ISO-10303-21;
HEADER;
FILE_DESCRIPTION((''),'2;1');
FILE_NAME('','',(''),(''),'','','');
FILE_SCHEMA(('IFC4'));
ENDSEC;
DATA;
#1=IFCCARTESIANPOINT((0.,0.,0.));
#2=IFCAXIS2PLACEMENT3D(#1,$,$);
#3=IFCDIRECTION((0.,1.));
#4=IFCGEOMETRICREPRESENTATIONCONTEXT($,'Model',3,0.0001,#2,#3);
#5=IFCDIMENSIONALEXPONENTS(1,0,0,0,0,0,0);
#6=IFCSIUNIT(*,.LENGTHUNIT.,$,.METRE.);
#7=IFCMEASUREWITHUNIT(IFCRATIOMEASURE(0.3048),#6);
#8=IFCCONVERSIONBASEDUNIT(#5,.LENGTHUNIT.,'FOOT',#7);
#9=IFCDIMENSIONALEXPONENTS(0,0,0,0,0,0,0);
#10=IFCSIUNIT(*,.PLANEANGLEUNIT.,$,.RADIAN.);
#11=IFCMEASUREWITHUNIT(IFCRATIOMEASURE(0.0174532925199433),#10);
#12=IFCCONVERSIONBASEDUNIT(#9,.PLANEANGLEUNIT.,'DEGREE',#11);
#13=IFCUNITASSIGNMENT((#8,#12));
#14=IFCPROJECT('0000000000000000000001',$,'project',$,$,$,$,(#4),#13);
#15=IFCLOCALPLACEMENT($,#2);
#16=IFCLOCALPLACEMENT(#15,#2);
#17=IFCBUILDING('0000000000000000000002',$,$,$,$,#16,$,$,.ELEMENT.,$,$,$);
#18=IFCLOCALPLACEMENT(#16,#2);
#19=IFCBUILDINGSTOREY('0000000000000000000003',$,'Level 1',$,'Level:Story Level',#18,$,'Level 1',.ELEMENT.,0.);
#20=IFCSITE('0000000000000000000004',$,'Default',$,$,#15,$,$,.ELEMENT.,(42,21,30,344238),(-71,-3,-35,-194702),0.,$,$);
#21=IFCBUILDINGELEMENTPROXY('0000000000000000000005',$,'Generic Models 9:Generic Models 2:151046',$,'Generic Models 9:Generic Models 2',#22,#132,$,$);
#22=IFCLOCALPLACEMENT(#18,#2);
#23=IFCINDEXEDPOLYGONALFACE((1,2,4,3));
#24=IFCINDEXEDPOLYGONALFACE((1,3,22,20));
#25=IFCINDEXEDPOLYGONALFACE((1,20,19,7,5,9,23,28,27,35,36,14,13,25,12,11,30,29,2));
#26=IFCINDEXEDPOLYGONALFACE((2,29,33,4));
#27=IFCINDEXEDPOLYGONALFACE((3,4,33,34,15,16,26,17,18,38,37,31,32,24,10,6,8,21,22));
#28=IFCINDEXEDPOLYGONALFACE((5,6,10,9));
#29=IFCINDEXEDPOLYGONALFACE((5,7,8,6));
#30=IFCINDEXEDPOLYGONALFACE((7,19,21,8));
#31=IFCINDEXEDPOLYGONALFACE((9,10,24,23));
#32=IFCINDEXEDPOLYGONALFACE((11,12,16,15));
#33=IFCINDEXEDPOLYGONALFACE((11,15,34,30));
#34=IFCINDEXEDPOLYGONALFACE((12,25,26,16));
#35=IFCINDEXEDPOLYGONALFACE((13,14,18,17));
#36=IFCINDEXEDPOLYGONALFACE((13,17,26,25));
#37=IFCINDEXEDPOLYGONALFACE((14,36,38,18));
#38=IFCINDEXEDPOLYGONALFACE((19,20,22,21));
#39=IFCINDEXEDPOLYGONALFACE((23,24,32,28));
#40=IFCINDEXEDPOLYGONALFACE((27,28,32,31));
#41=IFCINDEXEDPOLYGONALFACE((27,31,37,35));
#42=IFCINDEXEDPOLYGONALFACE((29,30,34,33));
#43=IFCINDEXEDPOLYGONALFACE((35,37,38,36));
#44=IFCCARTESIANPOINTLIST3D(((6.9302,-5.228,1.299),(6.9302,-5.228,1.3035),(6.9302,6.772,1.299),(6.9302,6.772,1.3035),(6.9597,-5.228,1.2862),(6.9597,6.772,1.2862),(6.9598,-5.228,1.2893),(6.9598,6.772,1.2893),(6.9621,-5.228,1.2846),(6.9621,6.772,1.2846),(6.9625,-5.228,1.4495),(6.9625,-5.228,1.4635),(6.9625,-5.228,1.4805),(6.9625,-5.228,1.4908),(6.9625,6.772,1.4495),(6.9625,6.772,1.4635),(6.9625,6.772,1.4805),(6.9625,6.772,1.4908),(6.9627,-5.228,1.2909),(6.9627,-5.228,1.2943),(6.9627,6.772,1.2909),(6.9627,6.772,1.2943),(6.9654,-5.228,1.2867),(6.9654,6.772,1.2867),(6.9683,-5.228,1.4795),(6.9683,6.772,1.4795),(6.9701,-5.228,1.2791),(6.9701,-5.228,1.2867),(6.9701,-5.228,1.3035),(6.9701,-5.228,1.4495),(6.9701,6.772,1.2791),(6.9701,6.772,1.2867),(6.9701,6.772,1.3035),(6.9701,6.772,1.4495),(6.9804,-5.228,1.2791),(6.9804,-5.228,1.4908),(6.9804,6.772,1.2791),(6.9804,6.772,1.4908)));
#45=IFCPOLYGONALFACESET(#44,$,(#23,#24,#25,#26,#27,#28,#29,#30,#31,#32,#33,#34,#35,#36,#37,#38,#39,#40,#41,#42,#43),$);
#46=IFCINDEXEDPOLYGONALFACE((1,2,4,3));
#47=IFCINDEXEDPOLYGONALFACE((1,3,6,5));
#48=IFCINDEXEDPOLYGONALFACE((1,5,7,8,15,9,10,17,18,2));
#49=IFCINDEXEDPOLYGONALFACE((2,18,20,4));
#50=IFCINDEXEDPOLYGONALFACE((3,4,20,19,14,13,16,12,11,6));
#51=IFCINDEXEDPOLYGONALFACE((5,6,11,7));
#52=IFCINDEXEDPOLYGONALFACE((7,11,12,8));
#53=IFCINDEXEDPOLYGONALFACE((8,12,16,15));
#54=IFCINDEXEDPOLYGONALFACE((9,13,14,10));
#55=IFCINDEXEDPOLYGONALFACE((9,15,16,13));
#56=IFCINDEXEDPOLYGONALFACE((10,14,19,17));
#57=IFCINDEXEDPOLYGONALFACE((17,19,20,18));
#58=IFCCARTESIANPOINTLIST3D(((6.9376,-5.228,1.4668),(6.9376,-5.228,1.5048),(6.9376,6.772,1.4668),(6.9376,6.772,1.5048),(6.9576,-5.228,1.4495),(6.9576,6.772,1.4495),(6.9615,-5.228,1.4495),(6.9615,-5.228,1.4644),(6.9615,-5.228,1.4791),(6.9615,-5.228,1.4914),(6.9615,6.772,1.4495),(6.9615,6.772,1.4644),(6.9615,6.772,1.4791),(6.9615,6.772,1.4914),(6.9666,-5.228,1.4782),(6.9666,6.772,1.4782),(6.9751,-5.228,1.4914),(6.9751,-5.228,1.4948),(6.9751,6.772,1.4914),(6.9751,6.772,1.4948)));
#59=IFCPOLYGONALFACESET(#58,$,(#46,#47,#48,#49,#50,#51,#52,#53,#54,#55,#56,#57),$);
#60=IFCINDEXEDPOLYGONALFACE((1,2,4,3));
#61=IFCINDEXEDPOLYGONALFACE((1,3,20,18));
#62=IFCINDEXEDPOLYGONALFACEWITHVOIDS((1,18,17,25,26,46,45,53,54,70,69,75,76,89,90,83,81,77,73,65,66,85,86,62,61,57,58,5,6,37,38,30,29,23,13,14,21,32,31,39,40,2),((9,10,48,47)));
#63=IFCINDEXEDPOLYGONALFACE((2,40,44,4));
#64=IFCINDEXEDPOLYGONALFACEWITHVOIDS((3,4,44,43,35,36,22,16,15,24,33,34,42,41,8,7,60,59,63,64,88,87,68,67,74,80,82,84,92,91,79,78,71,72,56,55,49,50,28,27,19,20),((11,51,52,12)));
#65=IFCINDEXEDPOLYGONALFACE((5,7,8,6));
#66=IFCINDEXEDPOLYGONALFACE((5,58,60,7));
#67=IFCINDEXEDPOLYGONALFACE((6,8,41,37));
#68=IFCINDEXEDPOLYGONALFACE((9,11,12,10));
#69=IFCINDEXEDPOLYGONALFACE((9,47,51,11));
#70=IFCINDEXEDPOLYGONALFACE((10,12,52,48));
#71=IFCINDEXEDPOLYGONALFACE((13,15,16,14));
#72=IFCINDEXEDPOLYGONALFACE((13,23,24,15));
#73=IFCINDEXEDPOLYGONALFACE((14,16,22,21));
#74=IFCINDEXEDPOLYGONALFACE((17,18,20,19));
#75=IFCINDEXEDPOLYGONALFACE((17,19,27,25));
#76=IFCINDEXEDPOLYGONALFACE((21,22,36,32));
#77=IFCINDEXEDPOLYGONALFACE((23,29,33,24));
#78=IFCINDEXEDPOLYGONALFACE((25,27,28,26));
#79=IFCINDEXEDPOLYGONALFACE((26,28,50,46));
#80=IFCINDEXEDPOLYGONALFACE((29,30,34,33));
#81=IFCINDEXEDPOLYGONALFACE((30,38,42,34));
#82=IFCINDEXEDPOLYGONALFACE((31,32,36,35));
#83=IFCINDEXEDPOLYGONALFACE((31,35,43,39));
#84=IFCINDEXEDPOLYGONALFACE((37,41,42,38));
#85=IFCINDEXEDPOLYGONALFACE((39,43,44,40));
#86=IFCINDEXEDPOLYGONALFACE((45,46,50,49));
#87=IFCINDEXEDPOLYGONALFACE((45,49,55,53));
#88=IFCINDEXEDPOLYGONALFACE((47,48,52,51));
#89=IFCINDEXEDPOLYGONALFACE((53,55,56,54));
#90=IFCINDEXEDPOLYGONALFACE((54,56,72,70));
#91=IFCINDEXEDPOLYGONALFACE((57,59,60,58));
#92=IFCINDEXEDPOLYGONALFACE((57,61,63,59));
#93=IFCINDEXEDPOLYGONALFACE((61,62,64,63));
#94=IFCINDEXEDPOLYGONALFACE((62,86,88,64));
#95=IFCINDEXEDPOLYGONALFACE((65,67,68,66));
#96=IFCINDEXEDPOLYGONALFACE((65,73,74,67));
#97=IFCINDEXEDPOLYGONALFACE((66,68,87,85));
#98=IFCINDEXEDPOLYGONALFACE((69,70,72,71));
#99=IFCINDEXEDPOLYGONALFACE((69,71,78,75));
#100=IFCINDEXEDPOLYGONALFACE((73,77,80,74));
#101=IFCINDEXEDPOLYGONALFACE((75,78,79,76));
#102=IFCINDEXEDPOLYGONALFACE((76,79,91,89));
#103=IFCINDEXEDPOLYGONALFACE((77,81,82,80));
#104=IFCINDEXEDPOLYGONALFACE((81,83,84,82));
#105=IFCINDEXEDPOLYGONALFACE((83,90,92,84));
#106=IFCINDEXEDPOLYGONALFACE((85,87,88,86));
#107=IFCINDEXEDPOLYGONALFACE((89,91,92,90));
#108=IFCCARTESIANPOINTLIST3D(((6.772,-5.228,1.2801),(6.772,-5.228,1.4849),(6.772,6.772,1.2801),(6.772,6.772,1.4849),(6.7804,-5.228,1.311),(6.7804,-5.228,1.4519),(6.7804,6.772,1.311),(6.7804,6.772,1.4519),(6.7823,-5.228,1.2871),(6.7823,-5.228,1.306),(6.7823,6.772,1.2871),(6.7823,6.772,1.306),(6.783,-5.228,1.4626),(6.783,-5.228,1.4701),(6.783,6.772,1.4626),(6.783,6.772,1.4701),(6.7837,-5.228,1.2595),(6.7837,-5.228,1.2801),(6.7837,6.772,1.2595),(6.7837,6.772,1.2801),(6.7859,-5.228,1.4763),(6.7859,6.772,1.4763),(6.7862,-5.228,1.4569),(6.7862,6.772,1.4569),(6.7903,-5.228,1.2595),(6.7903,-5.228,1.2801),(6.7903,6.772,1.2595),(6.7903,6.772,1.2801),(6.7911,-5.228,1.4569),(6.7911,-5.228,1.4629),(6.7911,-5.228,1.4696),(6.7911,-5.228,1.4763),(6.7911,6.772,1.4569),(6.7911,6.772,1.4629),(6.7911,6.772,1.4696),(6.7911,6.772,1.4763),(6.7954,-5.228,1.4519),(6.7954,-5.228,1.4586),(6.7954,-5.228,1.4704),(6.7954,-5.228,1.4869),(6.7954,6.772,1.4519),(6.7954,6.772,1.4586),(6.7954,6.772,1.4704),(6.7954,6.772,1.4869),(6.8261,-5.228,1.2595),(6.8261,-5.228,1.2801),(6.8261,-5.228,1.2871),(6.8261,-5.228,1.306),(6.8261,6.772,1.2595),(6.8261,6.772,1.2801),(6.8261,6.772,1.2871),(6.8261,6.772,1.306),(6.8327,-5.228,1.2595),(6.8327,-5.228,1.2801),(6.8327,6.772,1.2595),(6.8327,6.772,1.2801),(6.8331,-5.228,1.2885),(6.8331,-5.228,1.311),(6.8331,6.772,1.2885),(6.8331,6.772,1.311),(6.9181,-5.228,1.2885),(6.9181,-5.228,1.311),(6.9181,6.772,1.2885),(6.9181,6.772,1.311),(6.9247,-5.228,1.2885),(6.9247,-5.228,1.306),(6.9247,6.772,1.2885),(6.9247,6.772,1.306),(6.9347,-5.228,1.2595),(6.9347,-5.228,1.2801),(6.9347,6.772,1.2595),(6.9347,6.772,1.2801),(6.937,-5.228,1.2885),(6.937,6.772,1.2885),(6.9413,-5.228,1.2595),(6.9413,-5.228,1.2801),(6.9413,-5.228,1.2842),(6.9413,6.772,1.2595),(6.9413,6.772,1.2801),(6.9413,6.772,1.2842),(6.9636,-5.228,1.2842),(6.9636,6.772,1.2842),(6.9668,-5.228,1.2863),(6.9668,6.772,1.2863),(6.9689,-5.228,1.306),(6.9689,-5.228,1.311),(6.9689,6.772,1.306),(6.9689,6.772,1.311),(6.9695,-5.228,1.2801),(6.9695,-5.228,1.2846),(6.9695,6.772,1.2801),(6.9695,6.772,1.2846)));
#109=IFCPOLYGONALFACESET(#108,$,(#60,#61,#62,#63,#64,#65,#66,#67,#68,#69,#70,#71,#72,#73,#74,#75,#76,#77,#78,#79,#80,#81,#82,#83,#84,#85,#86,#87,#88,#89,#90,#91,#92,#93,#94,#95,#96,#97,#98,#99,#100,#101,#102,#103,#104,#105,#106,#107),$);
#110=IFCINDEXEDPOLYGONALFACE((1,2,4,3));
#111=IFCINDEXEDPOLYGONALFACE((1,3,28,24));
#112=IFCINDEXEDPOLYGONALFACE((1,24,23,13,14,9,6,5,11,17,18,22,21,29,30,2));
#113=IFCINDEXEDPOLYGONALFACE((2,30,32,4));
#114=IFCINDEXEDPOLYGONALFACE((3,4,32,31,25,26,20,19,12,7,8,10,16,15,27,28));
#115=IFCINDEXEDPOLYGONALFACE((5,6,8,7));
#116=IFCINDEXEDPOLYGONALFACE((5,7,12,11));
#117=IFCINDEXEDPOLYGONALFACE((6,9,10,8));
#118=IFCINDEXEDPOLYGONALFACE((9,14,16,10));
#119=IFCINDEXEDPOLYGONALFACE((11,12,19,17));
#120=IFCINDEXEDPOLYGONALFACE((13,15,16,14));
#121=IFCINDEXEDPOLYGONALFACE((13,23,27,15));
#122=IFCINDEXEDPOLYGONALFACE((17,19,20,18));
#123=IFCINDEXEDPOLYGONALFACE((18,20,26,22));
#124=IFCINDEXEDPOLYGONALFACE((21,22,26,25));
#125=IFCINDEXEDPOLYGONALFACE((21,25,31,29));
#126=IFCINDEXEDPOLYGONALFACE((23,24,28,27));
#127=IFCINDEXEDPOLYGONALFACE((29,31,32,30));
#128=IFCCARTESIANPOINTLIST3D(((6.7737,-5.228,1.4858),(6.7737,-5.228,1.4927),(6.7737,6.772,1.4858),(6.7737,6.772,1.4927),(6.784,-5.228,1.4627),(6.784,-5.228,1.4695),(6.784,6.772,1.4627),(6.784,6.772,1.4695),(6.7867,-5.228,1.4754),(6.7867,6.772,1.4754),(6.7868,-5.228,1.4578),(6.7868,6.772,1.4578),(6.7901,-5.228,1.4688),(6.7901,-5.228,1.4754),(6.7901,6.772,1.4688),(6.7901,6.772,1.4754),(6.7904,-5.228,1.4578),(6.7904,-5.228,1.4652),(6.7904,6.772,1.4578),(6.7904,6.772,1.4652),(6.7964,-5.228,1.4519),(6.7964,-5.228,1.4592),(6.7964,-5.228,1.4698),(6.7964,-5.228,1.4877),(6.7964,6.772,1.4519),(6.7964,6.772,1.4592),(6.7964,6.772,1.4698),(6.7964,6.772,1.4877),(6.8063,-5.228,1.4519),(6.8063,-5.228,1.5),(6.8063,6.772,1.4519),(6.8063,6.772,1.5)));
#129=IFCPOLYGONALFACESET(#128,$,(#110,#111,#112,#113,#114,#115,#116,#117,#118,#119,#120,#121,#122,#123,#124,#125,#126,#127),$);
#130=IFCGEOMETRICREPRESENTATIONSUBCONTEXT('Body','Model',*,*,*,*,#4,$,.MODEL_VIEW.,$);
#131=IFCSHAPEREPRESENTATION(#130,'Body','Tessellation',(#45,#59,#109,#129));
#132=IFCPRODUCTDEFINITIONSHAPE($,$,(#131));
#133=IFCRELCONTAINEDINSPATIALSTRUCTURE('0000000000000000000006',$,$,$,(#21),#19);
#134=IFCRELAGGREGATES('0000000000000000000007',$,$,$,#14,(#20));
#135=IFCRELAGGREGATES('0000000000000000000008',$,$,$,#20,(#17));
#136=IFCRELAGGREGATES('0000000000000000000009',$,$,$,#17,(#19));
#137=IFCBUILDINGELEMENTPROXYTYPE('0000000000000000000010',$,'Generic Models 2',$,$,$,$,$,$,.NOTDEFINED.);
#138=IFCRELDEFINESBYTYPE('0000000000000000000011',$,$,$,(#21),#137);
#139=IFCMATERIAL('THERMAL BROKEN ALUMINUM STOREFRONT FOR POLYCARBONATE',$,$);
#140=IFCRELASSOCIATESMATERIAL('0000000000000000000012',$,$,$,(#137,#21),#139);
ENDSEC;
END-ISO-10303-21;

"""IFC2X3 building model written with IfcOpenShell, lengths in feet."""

from ifc_helpers import new_model, entity, si_unit, converted_unit, direction, frame, origin, place, context, subcontext, project, spatial, polyline, outline, extrude, source, transform, mapped, material, type_object, type_shapes, element, save


model = new_model("IFC2X3")

# Units and contexts
model_context = context("Model", 3, precision=0.0001, world=origin(), true_north=direction((0.0, 1.0)))
body_context = subcontext(model_context, "Body", "Model", "MODEL_VIEW")
ifc_project = project(units=[converted_unit("LENGTHUNIT", "FOOT", entity("IfcRatioMeasure", 0.3048), si_unit("LENGTHUNIT", "METRE"), dimensions=[1, 0, 0, 0, 0, 0, 0]), converted_unit("PLANEANGLEUNIT", "DEGREE", entity("IfcRatioMeasure", 0.0174532925199433), si_unit("PLANEANGLEUNIT", "RADIAN"), dimensions=[0, 0, 0, 0, 0, 0, 0])], contexts=[model_context])

# Site, building, storey
site_placement = place(None, origin())
site = spatial("IfcSite", under=ifc_project, at=site_placement, Name="Default", CompositionType="ELEMENT", RefLatitude=(42, 21, 30, 344238), RefLongitude=(-71, -3, -35, -194702), RefElevation=0.0)
building_placement = place(site_placement, origin())
building = spatial("IfcBuilding", under=site, at=building_placement, CompositionType="ELEMENT")
storey_placement = place(building_placement, origin())
storey = spatial("IfcBuildingStorey", under=building, at=storey_placement, Name="Level 1", ObjectType="Level:Story Level", LongName="Level 1", CompositionType="ELEMENT", Elevation=0.0)

# Building element proxy
ifc_material = material(Name="THERMAL BROKEN ALUMINUM STOREFRONT FOR POLYCARBONATE")
building_element_proxy_type_1 = type_object("IfcBuildingElementProxyType", Name="Generic Models 2", PredefinedType="NOTDEFINED", material=ifc_material)
shared_shape_1 = source(origin(), body_context, "Body", "SweptSolid", [
    extrude(outline(polyline([(-0.0355, -0.058), (-0.0371, -0.0606), (-0.0358, -0.0632), (-0.0318, -0.063), (-0.0278, -0.0652), (-0.0315, -0.0718), (-0.0224, -0.0768), (0.0802, 0.1083), (0.0645, 0.1169), (0.0595, 0.1079), (0.0642, 0.1042), (0.0513, 0.0931), (0.0445, 0.0809), (0.0512, 0.0772), (-0.0197, -0.0506), (-0.0545, -0.0312), (-0.0567, -0.0352), (-0.0306, -0.055), (-0.0322, -0.058), (-0.0355, -0.058)])), frame((0.0, -0.1907, 0.0977), z_axis=(-1.0, 0.0, 0.0), x_axis=(0.0, -0.874529, 0.484974)), (0.0, 0.0, -1.0), 12.0),
    extrude(outline(polyline([(-0.0178, -0.0155), (-0.0144, -0.0155), (-0.0144, -0.002), (-0.0021, -0.002), (-0.0012, -0.007), (0.0126, -0.002), (0.0275, -0.002), (0.0275, 0.002), (0.0102, 0.022), (-0.0278, 0.022), (-0.0178, -0.0155)])), frame((0.0, -0.1875, 0.2175), z_axis=(1.0, 0.0, 0.0), x_axis=(0.0, 0.0, -1.0)), (0.0, 0.0, 1.0), 12.0),
    extrude(outline(polyline([(-0.107, -0.073), (-0.107, -0.058), (-0.1137, -0.058), (-0.118, -0.0623), (-0.1121, -0.0623), (-0.1121, -0.0672), (-0.1177, -0.0704), (-0.1252, -0.0704), (-0.1315, -0.0675), (-0.1315, -0.0623), (-0.1248, -0.0623), (-0.1255, -0.058), (-0.142, -0.058), (-0.1401, -0.0814), (0.0647, -0.0814), (0.0647, -0.0697), (0.0853, -0.0697), (0.0853, -0.0631), (0.0647, -0.0631), (0.0647, -0.0273), (0.0853, -0.0273), (0.0853, -0.0207), (0.0647, -0.0207), (0.0647, 0.0812), (0.0853, 0.0812), (0.0853, 0.0878), (0.0647, 0.0878), (0.0647, 0.1161), (0.0603, 0.1161), (0.0585, 0.1133), (0.0606, 0.1102), (0.0606, 0.0878), (0.0564, 0.0836), (0.0564, 0.0713), (0.0389, 0.0713), (0.0389, 0.1155), (0.0338, 0.1155), (0.0338, 0.0647), (0.0564, 0.0647), (0.0564, -0.0203), (0.0338, -0.0203), (0.0338, -0.073), (-0.107, -0.073)]), holes=[polyline([(0.0577, -0.0711), (0.0389, -0.0711), (0.0389, -0.0273), (0.0577, -0.0273), (0.0577, -0.0711)])]), frame((0.0, -0.0814, 0.0853), z_axis=(-1.0, 0.0, 0.0), x_axis=(0.0, 0.0, -1.0)), (0.0, 0.0, -1.0), 12.0),
    extrude(outline(polyline([(-0.0292, -0.0159), (0.0189, -0.0159), (0.0189, -0.0059), (0.0115, -0.0059), (0.0055, 0.0001), (0.0129, 0.0001), (0.0129, 0.0037), (0.008, 0.0065), (0.0012, 0.0065), (-0.0047, 0.0038), (-0.0047, 0.0004), (0.002, 0.0004), (0.0009, -0.0059), (-0.017, -0.0059), (-0.015, 0.0168), (-0.0219, 0.0168), (-0.0292, -0.0159)])), frame((0.0, -0.0185, 0.2112), z_axis=(1.0, 0.0, 0.0), x_axis=(0.0, 0.0, -1.0)), (0.0, 0.0, 1.0), 12.0),
])
type_shapes(building_element_proxy_type_1, [shared_shape_1])
proxy_1_placement = place(storey_placement, frame((6.772, -5.228, 1.2595), z_axis=(0.0, 0.0, 1.0), x_axis=(0.0, 1.0, 0.0)))
element("IfcBuildingElementProxy", 1, at=proxy_1_placement, inside=storey, type_object=building_element_proxy_type_1, material=ifc_material, Name="Generic Models 9:Generic Models 2:151046", ObjectType="Generic Models 9:Generic Models 2", context=body_context, shape_type="MappedRepresentation", body=[
    mapped(shared_shape_1, transform((0.0, 0.0, 0.0), scale=1.0)),
])

save(model, "model.ifc")
